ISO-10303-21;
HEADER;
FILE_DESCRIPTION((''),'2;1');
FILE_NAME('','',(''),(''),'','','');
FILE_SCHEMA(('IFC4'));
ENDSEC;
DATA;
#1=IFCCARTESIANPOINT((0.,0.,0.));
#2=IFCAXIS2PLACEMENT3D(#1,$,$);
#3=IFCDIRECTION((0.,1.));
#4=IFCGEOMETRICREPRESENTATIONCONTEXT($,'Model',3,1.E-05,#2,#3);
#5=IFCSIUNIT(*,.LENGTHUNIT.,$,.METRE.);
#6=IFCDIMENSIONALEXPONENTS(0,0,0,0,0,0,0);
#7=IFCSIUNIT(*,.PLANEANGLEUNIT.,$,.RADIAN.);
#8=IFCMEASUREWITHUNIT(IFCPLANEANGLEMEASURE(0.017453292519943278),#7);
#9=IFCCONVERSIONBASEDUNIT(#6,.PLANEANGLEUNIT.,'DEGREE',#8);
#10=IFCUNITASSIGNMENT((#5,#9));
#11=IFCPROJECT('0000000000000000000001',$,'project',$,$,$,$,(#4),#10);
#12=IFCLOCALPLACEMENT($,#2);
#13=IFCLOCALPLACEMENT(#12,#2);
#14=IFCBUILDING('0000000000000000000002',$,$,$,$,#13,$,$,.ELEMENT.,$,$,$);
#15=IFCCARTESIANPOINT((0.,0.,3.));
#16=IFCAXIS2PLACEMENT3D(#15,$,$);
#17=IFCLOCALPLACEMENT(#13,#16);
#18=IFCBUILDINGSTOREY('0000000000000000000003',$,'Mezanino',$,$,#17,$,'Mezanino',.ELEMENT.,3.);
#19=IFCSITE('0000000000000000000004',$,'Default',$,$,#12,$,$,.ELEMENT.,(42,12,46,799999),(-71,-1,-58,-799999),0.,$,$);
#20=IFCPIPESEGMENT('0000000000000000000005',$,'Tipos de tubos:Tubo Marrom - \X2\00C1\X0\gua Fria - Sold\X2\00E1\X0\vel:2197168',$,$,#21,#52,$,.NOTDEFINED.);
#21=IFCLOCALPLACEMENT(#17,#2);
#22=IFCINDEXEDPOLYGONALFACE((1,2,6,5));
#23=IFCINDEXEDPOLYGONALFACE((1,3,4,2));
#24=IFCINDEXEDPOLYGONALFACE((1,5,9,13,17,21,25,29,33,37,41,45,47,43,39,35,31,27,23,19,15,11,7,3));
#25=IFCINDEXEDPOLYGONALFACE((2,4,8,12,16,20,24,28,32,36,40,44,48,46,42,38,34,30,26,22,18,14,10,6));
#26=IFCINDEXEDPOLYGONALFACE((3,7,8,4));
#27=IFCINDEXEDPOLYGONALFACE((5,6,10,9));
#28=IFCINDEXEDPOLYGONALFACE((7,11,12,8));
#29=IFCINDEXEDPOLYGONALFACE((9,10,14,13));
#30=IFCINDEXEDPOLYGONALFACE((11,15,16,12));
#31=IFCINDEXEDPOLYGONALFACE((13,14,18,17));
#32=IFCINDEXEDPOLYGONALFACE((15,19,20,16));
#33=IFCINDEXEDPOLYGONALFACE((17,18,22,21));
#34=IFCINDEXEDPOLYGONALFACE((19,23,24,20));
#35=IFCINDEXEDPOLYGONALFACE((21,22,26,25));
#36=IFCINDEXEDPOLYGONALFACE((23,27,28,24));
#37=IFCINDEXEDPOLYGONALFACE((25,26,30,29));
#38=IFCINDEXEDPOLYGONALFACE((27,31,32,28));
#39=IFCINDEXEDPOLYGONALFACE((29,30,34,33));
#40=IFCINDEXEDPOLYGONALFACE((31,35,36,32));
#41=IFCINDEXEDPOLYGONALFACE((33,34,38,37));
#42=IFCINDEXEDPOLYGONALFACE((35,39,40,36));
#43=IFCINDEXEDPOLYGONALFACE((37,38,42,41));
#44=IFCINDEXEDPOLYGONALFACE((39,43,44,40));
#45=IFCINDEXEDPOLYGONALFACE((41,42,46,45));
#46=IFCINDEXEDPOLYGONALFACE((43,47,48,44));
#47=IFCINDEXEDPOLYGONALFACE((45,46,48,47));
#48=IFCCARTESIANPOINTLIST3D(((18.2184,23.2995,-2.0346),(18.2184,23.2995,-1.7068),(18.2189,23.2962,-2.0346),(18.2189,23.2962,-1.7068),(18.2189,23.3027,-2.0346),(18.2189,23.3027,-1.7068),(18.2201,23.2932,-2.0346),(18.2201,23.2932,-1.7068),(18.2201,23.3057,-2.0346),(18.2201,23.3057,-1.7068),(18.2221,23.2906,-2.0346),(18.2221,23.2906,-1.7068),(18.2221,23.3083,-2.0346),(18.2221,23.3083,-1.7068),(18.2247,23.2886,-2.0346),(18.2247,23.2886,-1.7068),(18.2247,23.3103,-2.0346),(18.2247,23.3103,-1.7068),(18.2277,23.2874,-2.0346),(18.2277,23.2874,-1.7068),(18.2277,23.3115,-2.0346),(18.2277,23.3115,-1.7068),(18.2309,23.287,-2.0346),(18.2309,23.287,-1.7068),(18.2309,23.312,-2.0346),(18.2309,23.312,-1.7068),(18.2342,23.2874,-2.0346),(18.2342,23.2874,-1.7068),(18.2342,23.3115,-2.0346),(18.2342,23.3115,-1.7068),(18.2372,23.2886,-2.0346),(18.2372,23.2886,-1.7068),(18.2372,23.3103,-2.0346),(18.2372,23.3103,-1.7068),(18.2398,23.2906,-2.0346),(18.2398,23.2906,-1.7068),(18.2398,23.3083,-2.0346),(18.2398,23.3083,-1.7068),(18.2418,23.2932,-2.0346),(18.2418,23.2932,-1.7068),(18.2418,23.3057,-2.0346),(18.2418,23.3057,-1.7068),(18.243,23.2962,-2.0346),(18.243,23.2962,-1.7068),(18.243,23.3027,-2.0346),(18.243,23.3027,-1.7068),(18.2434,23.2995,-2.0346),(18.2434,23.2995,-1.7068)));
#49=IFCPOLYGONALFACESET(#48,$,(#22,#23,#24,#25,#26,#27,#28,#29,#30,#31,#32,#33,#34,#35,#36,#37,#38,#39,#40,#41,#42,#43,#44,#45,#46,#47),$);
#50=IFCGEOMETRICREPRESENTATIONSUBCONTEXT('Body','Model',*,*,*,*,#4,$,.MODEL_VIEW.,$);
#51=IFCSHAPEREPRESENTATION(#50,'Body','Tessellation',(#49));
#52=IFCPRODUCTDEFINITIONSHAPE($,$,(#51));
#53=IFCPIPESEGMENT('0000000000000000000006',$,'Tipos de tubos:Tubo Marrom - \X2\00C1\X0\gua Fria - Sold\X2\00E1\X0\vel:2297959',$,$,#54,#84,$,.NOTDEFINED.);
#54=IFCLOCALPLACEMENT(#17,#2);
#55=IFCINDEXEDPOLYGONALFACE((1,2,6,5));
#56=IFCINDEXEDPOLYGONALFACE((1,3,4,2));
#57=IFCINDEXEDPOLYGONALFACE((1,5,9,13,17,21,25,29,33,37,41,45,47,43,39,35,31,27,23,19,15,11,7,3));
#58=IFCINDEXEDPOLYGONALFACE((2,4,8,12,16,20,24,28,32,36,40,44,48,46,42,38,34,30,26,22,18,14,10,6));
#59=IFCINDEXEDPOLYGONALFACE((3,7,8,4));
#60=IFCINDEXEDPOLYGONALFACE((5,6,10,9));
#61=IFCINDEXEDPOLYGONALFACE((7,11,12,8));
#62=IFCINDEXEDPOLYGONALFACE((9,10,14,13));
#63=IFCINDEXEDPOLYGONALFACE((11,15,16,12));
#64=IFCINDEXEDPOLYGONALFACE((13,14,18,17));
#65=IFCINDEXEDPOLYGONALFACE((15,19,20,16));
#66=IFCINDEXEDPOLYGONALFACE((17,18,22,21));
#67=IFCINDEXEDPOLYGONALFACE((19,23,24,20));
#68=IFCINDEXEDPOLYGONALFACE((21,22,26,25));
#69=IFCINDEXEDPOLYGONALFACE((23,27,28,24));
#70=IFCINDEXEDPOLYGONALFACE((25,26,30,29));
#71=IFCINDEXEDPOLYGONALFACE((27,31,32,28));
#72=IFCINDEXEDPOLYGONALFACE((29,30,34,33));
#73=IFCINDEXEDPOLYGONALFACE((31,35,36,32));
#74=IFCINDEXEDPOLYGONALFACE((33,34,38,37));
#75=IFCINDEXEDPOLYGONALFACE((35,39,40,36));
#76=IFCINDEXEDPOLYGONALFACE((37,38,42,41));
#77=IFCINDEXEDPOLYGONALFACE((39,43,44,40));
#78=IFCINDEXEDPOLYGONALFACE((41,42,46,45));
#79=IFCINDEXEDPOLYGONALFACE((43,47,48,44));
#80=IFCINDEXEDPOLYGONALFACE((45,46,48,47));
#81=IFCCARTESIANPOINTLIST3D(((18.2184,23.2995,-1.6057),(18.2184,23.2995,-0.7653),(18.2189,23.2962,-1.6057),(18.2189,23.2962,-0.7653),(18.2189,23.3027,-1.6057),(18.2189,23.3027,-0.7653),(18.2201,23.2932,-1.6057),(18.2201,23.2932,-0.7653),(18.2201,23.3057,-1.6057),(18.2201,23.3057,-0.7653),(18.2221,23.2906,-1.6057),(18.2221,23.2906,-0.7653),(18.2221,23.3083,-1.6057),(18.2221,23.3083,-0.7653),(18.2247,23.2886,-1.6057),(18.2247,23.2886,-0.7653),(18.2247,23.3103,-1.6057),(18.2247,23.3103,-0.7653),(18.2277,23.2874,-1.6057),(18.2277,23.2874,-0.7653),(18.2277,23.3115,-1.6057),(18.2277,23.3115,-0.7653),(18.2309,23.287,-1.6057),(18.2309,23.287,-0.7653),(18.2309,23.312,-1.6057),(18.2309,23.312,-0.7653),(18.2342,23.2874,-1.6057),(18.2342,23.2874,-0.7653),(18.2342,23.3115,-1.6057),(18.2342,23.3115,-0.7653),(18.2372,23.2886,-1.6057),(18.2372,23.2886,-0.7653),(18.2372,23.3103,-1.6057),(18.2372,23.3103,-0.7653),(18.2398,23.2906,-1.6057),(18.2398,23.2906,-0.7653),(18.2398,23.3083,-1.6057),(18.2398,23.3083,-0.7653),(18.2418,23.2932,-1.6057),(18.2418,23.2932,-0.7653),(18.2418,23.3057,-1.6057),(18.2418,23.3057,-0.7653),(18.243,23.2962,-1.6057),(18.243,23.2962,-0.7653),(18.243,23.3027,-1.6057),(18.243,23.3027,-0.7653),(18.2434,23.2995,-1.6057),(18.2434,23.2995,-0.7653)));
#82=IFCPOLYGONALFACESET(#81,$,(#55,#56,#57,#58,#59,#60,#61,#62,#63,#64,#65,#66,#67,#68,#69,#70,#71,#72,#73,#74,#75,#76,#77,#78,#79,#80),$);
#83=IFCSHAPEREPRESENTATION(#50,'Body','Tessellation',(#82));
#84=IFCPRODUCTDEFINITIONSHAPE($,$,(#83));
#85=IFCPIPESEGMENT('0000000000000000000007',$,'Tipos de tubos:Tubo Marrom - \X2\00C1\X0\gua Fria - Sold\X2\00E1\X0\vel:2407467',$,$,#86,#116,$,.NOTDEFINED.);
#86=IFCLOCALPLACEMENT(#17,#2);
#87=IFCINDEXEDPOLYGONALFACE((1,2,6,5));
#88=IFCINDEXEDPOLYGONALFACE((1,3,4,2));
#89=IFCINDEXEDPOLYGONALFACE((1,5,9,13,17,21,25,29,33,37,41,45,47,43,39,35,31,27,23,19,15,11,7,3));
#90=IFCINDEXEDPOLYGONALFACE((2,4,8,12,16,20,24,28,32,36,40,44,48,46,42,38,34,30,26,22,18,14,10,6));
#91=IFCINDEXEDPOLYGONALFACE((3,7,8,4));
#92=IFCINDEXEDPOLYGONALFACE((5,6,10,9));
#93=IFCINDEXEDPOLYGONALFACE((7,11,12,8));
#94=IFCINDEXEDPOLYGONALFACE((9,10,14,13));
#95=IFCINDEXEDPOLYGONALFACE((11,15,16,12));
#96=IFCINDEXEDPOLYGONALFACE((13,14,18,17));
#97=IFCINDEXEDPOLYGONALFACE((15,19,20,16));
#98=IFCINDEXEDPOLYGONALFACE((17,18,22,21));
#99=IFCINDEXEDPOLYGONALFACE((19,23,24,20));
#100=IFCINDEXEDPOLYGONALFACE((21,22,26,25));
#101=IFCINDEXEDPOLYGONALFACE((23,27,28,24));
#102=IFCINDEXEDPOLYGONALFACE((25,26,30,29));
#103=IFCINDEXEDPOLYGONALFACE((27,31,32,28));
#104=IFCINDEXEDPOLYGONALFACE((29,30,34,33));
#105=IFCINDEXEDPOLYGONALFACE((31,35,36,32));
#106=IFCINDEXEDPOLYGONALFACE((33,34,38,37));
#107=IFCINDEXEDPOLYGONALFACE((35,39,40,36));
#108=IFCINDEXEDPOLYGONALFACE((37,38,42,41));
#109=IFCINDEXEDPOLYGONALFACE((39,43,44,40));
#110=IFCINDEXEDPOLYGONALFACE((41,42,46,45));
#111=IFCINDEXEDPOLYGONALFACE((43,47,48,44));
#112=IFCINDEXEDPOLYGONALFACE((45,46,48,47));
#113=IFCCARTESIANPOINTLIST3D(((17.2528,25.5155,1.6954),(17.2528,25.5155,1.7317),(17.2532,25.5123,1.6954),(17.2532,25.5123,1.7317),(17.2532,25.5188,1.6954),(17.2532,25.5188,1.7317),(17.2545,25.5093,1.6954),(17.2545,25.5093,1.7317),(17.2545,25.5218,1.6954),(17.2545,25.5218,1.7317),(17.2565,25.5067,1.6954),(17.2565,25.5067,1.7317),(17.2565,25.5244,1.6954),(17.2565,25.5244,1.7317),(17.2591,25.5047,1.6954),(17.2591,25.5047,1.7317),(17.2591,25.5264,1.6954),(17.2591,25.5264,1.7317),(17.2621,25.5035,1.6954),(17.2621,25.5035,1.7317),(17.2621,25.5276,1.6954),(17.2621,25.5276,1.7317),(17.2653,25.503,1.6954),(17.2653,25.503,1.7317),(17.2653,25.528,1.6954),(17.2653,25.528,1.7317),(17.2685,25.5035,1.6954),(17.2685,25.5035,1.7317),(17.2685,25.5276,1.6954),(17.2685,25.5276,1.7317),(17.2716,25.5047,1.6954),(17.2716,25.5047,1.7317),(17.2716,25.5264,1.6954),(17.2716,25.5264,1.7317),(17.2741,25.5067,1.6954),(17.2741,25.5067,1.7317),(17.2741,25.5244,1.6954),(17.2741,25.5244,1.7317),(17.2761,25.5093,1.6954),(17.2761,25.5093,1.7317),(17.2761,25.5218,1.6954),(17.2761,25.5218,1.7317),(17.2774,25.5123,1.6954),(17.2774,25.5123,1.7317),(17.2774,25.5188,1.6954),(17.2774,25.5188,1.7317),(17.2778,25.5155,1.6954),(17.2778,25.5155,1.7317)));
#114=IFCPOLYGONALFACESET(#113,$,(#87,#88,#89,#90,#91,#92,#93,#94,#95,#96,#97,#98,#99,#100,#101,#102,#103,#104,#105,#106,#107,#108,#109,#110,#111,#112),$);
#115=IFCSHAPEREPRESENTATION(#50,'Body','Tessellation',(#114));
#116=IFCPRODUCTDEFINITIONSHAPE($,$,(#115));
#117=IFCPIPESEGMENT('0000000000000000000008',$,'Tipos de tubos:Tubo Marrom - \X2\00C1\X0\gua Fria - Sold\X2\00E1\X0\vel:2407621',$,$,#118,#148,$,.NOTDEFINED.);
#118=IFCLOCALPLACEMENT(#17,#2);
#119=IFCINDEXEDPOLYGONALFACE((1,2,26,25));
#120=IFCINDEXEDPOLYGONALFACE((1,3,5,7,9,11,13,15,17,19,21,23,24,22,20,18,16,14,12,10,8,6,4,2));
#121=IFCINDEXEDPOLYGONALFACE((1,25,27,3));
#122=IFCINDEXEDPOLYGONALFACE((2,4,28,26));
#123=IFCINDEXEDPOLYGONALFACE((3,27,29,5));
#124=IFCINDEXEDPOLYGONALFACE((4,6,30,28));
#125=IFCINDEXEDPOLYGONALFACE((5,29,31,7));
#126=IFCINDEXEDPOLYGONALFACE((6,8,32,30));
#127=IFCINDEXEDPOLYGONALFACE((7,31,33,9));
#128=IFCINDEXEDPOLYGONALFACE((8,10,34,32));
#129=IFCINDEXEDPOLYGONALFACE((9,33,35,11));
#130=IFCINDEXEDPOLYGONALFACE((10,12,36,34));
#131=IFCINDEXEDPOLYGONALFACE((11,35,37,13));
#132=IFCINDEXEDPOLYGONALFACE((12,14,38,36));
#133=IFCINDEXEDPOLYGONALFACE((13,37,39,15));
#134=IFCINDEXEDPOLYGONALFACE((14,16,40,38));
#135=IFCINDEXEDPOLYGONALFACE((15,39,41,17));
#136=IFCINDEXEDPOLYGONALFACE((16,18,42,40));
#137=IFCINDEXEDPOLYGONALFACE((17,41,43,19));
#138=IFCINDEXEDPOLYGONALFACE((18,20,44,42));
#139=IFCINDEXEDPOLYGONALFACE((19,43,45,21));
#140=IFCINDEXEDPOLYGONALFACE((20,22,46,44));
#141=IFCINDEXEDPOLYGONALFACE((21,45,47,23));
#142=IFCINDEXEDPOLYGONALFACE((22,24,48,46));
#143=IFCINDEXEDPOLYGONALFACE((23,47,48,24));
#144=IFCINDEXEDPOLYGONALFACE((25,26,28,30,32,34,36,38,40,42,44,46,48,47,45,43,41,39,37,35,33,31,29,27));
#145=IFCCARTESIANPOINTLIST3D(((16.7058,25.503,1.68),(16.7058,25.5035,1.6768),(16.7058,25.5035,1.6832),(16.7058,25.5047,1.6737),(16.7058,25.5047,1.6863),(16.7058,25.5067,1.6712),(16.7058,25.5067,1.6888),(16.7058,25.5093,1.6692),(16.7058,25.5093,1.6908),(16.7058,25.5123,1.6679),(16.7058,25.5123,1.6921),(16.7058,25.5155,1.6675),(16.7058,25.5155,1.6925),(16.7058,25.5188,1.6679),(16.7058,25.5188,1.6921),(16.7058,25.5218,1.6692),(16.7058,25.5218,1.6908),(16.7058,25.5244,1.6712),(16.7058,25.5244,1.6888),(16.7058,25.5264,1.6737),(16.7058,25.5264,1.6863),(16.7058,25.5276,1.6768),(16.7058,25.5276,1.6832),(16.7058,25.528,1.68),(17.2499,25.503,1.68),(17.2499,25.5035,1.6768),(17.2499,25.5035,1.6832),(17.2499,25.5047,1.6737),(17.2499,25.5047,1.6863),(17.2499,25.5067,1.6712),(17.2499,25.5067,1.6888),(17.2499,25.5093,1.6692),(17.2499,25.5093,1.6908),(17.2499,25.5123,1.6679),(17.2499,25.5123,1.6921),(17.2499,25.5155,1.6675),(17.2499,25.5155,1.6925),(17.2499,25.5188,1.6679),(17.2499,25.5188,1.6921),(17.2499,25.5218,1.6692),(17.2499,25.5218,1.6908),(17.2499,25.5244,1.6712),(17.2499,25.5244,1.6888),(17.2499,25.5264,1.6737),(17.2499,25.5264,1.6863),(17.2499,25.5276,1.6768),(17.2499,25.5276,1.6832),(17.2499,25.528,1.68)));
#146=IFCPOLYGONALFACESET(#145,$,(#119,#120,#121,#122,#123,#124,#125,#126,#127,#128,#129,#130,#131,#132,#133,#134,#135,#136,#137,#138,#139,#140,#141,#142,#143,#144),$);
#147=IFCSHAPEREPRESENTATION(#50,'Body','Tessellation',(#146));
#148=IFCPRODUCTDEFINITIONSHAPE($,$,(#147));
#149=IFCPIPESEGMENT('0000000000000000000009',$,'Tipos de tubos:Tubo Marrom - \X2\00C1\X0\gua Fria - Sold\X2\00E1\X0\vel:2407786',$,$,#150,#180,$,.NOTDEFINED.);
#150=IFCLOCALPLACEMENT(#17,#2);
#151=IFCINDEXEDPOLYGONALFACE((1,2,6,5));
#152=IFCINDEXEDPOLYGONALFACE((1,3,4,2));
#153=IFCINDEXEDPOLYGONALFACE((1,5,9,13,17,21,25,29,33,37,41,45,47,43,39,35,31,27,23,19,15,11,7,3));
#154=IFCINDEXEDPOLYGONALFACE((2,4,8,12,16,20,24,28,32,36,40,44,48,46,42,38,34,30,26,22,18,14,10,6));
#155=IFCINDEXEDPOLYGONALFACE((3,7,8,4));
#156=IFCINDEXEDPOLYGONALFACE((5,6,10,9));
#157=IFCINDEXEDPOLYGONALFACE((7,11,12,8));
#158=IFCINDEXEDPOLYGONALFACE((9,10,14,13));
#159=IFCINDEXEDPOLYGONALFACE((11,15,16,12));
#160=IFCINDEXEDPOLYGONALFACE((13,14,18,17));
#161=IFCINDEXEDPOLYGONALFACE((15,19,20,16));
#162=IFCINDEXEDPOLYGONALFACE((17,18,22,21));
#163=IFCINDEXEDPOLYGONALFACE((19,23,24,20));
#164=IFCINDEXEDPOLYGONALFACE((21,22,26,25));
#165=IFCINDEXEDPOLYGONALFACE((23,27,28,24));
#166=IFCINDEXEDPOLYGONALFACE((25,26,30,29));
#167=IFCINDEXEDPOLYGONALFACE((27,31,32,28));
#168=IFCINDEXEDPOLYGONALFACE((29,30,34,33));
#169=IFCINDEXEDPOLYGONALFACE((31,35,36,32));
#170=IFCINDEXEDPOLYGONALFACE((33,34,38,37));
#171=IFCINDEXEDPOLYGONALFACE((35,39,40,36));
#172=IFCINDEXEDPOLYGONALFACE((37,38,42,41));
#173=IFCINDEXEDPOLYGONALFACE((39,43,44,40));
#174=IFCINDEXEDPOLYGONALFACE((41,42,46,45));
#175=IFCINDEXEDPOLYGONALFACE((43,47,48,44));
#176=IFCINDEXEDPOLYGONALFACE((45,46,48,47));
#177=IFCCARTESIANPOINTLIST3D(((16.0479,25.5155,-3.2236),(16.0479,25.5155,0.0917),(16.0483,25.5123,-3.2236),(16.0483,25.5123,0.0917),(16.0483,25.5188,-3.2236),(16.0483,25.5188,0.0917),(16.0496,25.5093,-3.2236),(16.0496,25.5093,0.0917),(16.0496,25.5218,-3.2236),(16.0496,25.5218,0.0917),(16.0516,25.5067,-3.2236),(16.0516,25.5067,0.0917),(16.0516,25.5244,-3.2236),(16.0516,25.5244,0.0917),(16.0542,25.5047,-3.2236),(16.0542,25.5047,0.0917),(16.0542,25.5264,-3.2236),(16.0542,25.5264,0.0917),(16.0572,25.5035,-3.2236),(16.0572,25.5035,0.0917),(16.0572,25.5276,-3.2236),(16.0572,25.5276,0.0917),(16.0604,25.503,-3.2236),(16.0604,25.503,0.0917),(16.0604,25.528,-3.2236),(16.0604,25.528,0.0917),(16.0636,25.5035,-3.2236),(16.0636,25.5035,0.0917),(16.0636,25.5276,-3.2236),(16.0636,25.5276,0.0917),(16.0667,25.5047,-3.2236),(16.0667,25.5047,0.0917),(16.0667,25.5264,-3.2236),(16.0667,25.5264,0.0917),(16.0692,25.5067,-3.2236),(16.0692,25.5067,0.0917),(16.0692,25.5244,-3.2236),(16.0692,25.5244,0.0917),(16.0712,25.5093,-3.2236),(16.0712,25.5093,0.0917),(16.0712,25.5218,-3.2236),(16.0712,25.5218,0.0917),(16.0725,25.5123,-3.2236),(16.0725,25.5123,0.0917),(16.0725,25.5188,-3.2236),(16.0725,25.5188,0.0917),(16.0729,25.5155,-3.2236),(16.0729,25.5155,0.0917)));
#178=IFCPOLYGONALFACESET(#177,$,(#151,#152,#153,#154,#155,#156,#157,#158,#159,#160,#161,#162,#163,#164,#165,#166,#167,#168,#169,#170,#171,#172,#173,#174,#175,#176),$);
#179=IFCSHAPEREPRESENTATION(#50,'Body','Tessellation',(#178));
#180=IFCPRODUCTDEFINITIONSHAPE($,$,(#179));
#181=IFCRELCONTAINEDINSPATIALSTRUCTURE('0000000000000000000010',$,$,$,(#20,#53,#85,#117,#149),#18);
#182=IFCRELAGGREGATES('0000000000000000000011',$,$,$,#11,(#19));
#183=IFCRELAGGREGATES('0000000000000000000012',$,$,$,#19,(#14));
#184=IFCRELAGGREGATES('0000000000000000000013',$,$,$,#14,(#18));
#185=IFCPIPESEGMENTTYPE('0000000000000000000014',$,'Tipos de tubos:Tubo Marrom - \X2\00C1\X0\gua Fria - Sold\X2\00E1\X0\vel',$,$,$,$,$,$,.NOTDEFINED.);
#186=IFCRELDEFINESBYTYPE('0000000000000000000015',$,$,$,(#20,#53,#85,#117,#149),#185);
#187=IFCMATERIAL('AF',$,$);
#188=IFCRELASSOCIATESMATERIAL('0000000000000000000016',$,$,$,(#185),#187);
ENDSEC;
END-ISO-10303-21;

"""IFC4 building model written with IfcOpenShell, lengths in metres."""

from ifc_helpers import new_model, entity, si_unit, converted_unit, direction, frame, origin, place, context, subcontext, project, spatial, arc, indexed_curve, outline, extrude, material, type_object, element, save


model = new_model("IFC4")

# Units and contexts
model_context = context("Model", 3, precision=1e-05, world=origin(), true_north=direction((0.0, 1.0)))
body_context = subcontext(model_context, "Body", "Model", "MODEL_VIEW")
ifc_project = project(units=[si_unit("LENGTHUNIT", "METRE"), converted_unit("PLANEANGLEUNIT", "DEGREE", entity("IfcPlaneAngleMeasure", 0.017453292519943278), si_unit("PLANEANGLEUNIT", "RADIAN"), dimensions=[0, 0, 0, 0, 0, 0, 0])], contexts=[model_context])

# Site, building, storey
site_placement = place(None, origin())
site = spatial("IfcSite", under=ifc_project, at=site_placement, Name="Default", CompositionType="ELEMENT", RefLatitude=(42, 12, 46, 799999), RefLongitude=(-71, -1, -58, -799999), RefElevation=0.0)
building_placement = place(site_placement, origin())
building = spatial("IfcBuilding", under=site, at=building_placement, CompositionType="ELEMENT")
storey_placement = place(building_placement, frame((0.0, 0.0, 3.0)))
storey = spatial("IfcBuildingStorey", under=building, at=storey_placement, Name="Mezanino", LongName="Mezanino", CompositionType="ELEMENT", Elevation=3.0)

# Pipe segments
ifc_material = material(Name="AF")
pipe_segment_type = type_object("IfcPipeSegmentType", Name="Tipos de tubos:Tubo Marrom - Água Fria - Soldável", PredefinedType="NOTDEFINED", material=ifc_material)
pipe_segment_1_placement = place(storey_placement, origin())
element("IfcPipeSegment", 1, at=pipe_segment_1_placement, inside=storey, type_object=pipe_segment_type, Name="Tipos de tubos:Tubo Marrom - Água Fria - Soldável:2197168", PredefinedType="NOTDEFINED", context=body_context, shape_type="SweptSolid", body=[
    extrude(outline(indexed_curve([(0.0125, 0.0), (0.0088, 0.0088), (0.0, 0.0125), (-0.0088, 0.0088), (-0.0125, 0.0), (-0.0088, -0.0088), (0.0, -0.0125), (0.0088, -0.0088)], segments=[arc(1, 2, 3), arc(3, 4, 5), arc(5, 6, 7), arc(7, 8, 1)], self_intersect=False)), frame((18.2309, 23.2995, -2.0346), z_axis=(0.0, 0.0, 1.0), x_axis=(-1.0, 0.0, 0.0)), (0.0, 0.0, 1.0), 0.3278),
])
pipe_segment_2_placement = place(storey_placement, origin())
element("IfcPipeSegment", 2, at=pipe_segment_2_placement, inside=storey, type_object=pipe_segment_type, Name="Tipos de tubos:Tubo Marrom - Água Fria - Soldável:2297959", PredefinedType="NOTDEFINED", context=body_context, shape_type="SweptSolid", body=[
    extrude(outline(indexed_curve([(0.0125, 0.0), (0.0088, 0.0088), (0.0, 0.0125), (-0.0088, 0.0088), (-0.0125, 0.0), (-0.0088, -0.0088), (0.0, -0.0125), (0.0088, -0.0088)], segments=[arc(1, 2, 3), arc(3, 4, 5), arc(5, 6, 7), arc(7, 8, 1)], self_intersect=False)), frame((18.2309, 23.2995, -1.6057)), (0.0, 0.0, 1.0), 0.8404),
])
pipe_segment_3_placement = place(storey_placement, origin())
element("IfcPipeSegment", 3, at=pipe_segment_3_placement, inside=storey, type_object=pipe_segment_type, Name="Tipos de tubos:Tubo Marrom - Água Fria - Soldável:2407467", PredefinedType="NOTDEFINED", context=body_context, shape_type="SweptSolid", body=[
    extrude(outline(indexed_curve([(0.0125, 0.0), (0.0088, 0.0088), (0.0, 0.0125), (-0.0088, 0.0088), (-0.0125, 0.0), (-0.0088, -0.0088), (0.0, -0.0125), (0.0088, -0.0088)], segments=[arc(1, 2, 3), arc(3, 4, 5), arc(5, 6, 7), arc(7, 8, 1)], self_intersect=False)), frame((17.2653, 25.5155, 1.6954)), (0.0, 0.0, 1.0), 0.0363),
])
pipe_segment_4_placement = place(storey_placement, origin())
element("IfcPipeSegment", 4, at=pipe_segment_4_placement, inside=storey, type_object=pipe_segment_type, Name="Tipos de tubos:Tubo Marrom - Água Fria - Soldável:2407621", PredefinedType="NOTDEFINED", context=body_context, shape_type="SweptSolid", body=[
    extrude(outline(indexed_curve([(0.0125, 0.0), (0.0088, 0.0088), (0.0, 0.0125), (-0.0088, 0.0088), (-0.0125, 0.0), (-0.0088, -0.0088), (0.0, -0.0125), (0.0088, -0.0088)], segments=[arc(1, 2, 3), arc(3, 4, 5), arc(5, 6, 7), arc(7, 8, 1)], self_intersect=False)), frame((16.7058, 25.5155, 1.68), z_axis=(1.0, 0.0, 0.0), x_axis=(0.0, 1.0, 0.0)), (0.0, 0.0, 1.0), 0.5441),
])
pipe_segment_5_placement = place(storey_placement, origin())
element("IfcPipeSegment", 5, at=pipe_segment_5_placement, inside=storey, type_object=pipe_segment_type, Name="Tipos de tubos:Tubo Marrom - Água Fria - Soldável:2407786", PredefinedType="NOTDEFINED", context=body_context, shape_type="SweptSolid", body=[
    extrude(outline(indexed_curve([(0.0125, 0.0), (0.0088, 0.0088), (0.0, 0.0125), (-0.0088, 0.0088), (-0.0125, 0.0), (-0.0088, -0.0088), (0.0, -0.0125), (0.0088, -0.0088)], segments=[arc(1, 2, 3), arc(3, 4, 5), arc(5, 6, 7), arc(7, 8, 1)], self_intersect=False)), frame((16.0604, 25.5155, -3.2236), z_axis=(0.0, 0.0, 1.0), x_axis=(-1.0, 0.0, 0.0)), (0.0, 0.0, 1.0), 3.3153),
])

save(model, "model.ifc")
